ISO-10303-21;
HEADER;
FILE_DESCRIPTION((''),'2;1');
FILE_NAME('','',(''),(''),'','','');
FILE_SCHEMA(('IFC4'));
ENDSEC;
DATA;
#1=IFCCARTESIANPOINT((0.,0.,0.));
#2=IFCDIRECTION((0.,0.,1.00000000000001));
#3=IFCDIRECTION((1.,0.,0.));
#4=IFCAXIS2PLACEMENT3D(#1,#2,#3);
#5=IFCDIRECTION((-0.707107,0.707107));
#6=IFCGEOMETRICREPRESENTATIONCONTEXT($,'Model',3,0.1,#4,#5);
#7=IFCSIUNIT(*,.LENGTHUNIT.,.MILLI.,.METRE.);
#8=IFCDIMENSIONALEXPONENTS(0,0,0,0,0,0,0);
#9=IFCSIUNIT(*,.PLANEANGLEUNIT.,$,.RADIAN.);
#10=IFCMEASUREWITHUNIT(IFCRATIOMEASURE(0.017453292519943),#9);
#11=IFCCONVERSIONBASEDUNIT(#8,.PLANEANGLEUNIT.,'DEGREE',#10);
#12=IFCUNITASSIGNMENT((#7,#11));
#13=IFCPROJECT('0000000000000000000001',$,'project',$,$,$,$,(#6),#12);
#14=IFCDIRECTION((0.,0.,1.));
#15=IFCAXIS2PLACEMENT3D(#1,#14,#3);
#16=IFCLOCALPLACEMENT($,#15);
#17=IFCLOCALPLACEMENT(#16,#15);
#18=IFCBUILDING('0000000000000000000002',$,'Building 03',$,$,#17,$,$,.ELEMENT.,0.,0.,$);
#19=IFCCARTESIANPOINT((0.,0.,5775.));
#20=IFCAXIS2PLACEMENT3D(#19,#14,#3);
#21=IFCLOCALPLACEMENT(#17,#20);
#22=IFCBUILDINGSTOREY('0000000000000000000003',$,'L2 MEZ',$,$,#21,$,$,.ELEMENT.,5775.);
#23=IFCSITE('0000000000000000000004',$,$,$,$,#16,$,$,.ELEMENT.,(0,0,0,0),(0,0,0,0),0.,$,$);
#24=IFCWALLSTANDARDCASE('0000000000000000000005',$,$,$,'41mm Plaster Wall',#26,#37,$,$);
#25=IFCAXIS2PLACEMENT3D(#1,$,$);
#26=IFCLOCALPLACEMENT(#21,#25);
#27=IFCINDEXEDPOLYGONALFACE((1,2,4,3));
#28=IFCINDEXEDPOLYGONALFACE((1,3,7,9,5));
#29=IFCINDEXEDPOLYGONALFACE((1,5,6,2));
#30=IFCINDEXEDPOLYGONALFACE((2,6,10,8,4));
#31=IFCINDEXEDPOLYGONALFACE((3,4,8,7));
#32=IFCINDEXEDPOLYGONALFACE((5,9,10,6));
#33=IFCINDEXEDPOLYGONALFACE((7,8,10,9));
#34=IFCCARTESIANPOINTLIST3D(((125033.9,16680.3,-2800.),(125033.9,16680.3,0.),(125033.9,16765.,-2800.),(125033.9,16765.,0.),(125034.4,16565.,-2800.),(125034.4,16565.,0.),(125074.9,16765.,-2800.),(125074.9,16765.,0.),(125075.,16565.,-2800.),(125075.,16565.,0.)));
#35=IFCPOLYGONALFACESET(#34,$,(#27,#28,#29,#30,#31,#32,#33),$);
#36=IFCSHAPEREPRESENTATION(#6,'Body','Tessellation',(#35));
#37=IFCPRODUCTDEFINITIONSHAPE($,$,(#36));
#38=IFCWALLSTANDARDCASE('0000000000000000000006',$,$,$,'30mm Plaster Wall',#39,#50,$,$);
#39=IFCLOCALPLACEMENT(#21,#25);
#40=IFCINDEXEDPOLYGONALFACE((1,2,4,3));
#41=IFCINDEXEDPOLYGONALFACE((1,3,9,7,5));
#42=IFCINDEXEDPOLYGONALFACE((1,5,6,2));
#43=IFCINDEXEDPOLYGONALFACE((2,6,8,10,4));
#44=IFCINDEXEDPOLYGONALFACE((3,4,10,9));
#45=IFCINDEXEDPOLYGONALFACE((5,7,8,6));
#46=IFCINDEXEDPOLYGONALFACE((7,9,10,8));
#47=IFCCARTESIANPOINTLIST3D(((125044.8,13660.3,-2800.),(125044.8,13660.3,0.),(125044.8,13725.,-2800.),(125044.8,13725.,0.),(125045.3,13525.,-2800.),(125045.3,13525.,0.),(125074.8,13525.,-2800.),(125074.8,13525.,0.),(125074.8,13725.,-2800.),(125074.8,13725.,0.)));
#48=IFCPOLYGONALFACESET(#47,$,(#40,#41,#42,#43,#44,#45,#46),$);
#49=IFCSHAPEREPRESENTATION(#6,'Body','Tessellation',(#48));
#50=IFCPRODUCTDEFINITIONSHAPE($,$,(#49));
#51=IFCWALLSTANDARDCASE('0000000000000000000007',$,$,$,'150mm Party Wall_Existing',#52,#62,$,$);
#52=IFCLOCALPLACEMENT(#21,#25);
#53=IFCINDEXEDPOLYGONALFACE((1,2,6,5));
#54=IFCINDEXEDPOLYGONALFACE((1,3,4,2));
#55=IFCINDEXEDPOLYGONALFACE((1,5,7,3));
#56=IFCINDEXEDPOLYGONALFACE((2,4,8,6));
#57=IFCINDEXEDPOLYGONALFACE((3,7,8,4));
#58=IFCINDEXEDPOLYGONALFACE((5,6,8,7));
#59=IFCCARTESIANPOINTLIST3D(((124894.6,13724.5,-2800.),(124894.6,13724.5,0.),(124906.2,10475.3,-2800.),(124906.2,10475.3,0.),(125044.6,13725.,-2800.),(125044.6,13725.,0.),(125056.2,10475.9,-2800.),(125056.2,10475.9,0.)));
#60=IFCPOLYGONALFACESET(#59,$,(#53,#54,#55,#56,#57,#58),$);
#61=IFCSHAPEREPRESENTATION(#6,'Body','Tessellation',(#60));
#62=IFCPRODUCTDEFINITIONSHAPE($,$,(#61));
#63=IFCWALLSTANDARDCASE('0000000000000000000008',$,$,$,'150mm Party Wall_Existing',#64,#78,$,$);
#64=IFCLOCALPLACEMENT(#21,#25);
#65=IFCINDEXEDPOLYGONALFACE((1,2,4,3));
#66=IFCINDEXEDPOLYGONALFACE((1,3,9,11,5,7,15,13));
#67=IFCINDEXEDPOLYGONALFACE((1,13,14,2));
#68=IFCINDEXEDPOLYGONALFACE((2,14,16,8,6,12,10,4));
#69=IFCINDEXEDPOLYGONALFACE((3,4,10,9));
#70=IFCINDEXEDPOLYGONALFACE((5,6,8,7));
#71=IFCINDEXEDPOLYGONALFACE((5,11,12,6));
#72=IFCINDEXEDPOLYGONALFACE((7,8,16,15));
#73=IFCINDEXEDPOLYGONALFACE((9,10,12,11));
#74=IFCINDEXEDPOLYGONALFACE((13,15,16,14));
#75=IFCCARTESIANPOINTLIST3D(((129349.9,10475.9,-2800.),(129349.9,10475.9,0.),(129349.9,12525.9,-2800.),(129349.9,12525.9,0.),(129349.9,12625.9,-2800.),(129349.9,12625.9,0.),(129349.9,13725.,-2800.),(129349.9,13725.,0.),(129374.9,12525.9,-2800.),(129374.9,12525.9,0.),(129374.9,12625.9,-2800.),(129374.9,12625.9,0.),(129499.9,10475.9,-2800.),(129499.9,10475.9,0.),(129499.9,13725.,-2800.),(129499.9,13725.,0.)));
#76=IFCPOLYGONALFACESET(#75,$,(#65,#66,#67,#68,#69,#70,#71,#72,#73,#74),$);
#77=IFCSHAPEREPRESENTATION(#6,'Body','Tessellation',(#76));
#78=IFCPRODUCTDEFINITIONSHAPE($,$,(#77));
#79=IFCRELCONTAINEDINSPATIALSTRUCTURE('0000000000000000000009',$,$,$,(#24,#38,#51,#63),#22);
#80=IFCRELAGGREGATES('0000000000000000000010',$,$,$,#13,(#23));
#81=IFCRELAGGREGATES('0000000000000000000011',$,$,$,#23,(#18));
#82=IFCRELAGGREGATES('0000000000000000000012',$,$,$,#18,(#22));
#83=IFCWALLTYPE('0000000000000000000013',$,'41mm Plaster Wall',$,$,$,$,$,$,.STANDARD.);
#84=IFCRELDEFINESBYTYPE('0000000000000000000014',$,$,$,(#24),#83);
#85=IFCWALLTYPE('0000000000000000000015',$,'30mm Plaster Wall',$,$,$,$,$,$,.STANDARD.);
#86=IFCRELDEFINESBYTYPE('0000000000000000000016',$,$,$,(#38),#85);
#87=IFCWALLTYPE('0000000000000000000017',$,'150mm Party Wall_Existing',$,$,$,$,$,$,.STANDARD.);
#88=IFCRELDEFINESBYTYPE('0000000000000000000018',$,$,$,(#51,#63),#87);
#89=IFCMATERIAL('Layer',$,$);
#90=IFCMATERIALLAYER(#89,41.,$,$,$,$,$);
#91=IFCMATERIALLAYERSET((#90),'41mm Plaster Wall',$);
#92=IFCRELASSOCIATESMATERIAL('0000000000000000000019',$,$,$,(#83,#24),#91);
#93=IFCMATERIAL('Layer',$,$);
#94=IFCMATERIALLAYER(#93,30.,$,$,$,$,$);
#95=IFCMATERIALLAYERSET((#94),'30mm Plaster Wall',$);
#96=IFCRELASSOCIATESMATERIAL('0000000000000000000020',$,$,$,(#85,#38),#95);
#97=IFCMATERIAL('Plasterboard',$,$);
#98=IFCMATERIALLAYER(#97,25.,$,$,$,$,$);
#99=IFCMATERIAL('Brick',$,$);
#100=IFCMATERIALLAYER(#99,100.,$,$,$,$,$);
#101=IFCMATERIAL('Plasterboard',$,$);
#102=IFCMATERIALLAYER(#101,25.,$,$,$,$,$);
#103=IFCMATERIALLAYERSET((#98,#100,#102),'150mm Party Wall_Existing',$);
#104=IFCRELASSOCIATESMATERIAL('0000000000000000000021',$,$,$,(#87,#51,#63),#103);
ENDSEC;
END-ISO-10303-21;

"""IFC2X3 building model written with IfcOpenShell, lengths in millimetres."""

from ifc_helpers import new_model, entity, si_unit, converted_unit, direction, frame, origin_with_axes, place, context, project, spatial, polyline, outline, extrude, material, layer, layer_set, layer_usage, type_object, element, save


model = new_model("IFC2X3")

# Units and contexts
model_context = context("Model", 3, precision=0.1, world=frame((0.0, 0.0, 0.0), z_axis=(0.0, 0.0, 1.00000000000001), x_axis=(1.0, 0.0, 0.0)), true_north=direction((-0.707107, 0.707107)))
ifc_project = project(units=[si_unit("LENGTHUNIT", "METRE", prefix="MILLI"), converted_unit("PLANEANGLEUNIT", "DEGREE", entity("IfcRatioMeasure", 0.017453292519943), si_unit("PLANEANGLEUNIT", "RADIAN"), dimensions=[0, 0, 0, 0, 0, 0, 0])], contexts=[model_context])

# Site, building, storey
site_placement = place(None, origin_with_axes())
site = spatial("IfcSite", under=ifc_project, at=site_placement, CompositionType="ELEMENT", RefLatitude=(0, 0, 0, 0), RefLongitude=(0, 0, 0, 0), RefElevation=0.0)
building_placement = place(site_placement, origin_with_axes())
building = spatial("IfcBuilding", under=site, at=building_placement, Name="Building 03", CompositionType="ELEMENT", ElevationOfRefHeight=0.0, ElevationOfTerrain=0.0)
storey_placement = place(building_placement, frame((0.0, 0.0, 5775.0), z_axis=(0.0, 0.0, 1.0), x_axis=(1.0, 0.0, 0.0)))
storey = spatial("IfcBuildingStorey", under=building, at=storey_placement, Name="L2 MEZ", CompositionType="ELEMENT", Elevation=5775.0)

# Walls
ifc_material_1 = material(Name="Layer")
ifc_layer_1 = layer(ifc_material_1, 41.0)
ifc_layer_set_1 = layer_set([ifc_layer_1], Name="41mm Plaster Wall")
ifc_layer_usage_1 = layer_usage(ifc_layer_set_1, "AXIS2", "POSITIVE", -20.5)
wall_type_1 = type_object("IfcWallType", Name="41mm Plaster Wall", PredefinedType="STANDARD", material=ifc_layer_set_1)
wall_1_placement = place(site_placement, frame((125054.4, 16765.0, 2975.0), z_axis=(0.0, 0.0, 1.0), x_axis=(0.000378, -1.0, 0.0)))
element("IfcWallStandardCase", 1, at=wall_1_placement, inside=storey, type_object=wall_type_1, material=ifc_layer_usage_1, ObjectType="41mm Plaster Wall", context=model_context, shape_type="SweptSolid", body=[
    extrude(outline(polyline([(200.0, -20.1), (84.7, -20.5), (0.0, -20.5), (0.0, 20.5), (200.0, 20.5), (200.0, -20.1)])), origin_with_axes(), (0.0, 0.0, 1.0), 2800.0),
])
ifc_material_2 = material(Name="Layer")
ifc_layer_2 = layer(ifc_material_2, 30.0)
ifc_layer_set_2 = layer_set([ifc_layer_2], Name="30mm Plaster Wall")
ifc_layer_usage_2 = layer_usage(ifc_layer_set_2, "AXIS2", "POSITIVE", -15.0)
wall_type_2 = type_object("IfcWallType", Name="30mm Plaster Wall", PredefinedType="STANDARD", material=ifc_layer_set_2)
wall_2_placement = place(site_placement, frame((125059.8, 13725.0, 2975.0), z_axis=(0.0, 0.0, 1.0), x_axis=(-0.000002, -1.0, 0.0)))
element("IfcWallStandardCase", 2, at=wall_2_placement, inside=storey, type_object=wall_type_2, material=ifc_layer_usage_2, ObjectType="30mm Plaster Wall", context=model_context, shape_type="SweptSolid", body=[
    extrude(outline(polyline([(200.0, -14.5), (64.7, -15.0), (0.0, -15.0), (0.0, 15.0), (200.0, 15.0), (200.0, -14.5)])), origin_with_axes(), (0.0, 0.0, 1.0), 2800.0),
])
ifc_material_3 = material(Name="Plasterboard")
ifc_layer_3 = layer(ifc_material_3, 25.0)
ifc_material_4 = material(Name="Brick")
ifc_layer_4 = layer(ifc_material_4, 100.0)
ifc_material_5 = material(Name="Plasterboard")
ifc_layer_5 = layer(ifc_material_5, 25.0)
ifc_layer_set_3 = layer_set([ifc_layer_3, ifc_layer_4, ifc_layer_5], Name="150mm Party Wall_Existing")
ifc_layer_usage_3 = layer_usage(ifc_layer_set_3, "AXIS2", "POSITIVE", -75.0)
wall_type_3 = type_object("IfcWallType", Name="150mm Party Wall_Existing", PredefinedType="STANDARD", material=ifc_layer_set_3)
wall_3_placement = place(site_placement, frame((124969.6, 13724.7, 2975.0), z_axis=(0.0, 0.0, 1.0), x_axis=(0.003593, -0.999994, 0.0)))
element("IfcWallStandardCase", 3, at=wall_3_placement, inside=storey, type_object=wall_type_3, material=ifc_layer_usage_3, ObjectType="150mm Party Wall_Existing", context=model_context, shape_type="SweptSolid", body=[
    extrude(outline(polyline([(3249.2, 75.0), (0.0, 75.0), (0.0, -75.0), (3249.2, -75.0), (3249.2, 75.0)])), origin_with_axes(), (0.0, 0.0, 1.0), 2800.0),
])
wall_4_placement = place(site_placement, frame((129424.9, 13725.0, 2975.0), z_axis=(0.0, 0.0, 1.0), x_axis=(0.0, -1.0, 0.0)))
element("IfcWallStandardCase", 4, at=wall_4_placement, inside=storey, type_object=wall_type_3, material=ifc_layer_usage_3, ObjectType="150mm Party Wall_Existing", context=model_context, shape_type="SweptSolid", body=[
    extrude(outline(polyline([(3249.1, 75.0), (0.0, 75.0), (0.0, -75.0), (1099.1, -75.0), (1099.1, -50.0), (1199.1, -50.0), (1199.1, -75.0), (3249.1, -75.0), (3249.1, 75.0)])), origin_with_axes(), (0.0, 0.0, 1.0), 2800.0),
])

save(model, "model.ifc")
